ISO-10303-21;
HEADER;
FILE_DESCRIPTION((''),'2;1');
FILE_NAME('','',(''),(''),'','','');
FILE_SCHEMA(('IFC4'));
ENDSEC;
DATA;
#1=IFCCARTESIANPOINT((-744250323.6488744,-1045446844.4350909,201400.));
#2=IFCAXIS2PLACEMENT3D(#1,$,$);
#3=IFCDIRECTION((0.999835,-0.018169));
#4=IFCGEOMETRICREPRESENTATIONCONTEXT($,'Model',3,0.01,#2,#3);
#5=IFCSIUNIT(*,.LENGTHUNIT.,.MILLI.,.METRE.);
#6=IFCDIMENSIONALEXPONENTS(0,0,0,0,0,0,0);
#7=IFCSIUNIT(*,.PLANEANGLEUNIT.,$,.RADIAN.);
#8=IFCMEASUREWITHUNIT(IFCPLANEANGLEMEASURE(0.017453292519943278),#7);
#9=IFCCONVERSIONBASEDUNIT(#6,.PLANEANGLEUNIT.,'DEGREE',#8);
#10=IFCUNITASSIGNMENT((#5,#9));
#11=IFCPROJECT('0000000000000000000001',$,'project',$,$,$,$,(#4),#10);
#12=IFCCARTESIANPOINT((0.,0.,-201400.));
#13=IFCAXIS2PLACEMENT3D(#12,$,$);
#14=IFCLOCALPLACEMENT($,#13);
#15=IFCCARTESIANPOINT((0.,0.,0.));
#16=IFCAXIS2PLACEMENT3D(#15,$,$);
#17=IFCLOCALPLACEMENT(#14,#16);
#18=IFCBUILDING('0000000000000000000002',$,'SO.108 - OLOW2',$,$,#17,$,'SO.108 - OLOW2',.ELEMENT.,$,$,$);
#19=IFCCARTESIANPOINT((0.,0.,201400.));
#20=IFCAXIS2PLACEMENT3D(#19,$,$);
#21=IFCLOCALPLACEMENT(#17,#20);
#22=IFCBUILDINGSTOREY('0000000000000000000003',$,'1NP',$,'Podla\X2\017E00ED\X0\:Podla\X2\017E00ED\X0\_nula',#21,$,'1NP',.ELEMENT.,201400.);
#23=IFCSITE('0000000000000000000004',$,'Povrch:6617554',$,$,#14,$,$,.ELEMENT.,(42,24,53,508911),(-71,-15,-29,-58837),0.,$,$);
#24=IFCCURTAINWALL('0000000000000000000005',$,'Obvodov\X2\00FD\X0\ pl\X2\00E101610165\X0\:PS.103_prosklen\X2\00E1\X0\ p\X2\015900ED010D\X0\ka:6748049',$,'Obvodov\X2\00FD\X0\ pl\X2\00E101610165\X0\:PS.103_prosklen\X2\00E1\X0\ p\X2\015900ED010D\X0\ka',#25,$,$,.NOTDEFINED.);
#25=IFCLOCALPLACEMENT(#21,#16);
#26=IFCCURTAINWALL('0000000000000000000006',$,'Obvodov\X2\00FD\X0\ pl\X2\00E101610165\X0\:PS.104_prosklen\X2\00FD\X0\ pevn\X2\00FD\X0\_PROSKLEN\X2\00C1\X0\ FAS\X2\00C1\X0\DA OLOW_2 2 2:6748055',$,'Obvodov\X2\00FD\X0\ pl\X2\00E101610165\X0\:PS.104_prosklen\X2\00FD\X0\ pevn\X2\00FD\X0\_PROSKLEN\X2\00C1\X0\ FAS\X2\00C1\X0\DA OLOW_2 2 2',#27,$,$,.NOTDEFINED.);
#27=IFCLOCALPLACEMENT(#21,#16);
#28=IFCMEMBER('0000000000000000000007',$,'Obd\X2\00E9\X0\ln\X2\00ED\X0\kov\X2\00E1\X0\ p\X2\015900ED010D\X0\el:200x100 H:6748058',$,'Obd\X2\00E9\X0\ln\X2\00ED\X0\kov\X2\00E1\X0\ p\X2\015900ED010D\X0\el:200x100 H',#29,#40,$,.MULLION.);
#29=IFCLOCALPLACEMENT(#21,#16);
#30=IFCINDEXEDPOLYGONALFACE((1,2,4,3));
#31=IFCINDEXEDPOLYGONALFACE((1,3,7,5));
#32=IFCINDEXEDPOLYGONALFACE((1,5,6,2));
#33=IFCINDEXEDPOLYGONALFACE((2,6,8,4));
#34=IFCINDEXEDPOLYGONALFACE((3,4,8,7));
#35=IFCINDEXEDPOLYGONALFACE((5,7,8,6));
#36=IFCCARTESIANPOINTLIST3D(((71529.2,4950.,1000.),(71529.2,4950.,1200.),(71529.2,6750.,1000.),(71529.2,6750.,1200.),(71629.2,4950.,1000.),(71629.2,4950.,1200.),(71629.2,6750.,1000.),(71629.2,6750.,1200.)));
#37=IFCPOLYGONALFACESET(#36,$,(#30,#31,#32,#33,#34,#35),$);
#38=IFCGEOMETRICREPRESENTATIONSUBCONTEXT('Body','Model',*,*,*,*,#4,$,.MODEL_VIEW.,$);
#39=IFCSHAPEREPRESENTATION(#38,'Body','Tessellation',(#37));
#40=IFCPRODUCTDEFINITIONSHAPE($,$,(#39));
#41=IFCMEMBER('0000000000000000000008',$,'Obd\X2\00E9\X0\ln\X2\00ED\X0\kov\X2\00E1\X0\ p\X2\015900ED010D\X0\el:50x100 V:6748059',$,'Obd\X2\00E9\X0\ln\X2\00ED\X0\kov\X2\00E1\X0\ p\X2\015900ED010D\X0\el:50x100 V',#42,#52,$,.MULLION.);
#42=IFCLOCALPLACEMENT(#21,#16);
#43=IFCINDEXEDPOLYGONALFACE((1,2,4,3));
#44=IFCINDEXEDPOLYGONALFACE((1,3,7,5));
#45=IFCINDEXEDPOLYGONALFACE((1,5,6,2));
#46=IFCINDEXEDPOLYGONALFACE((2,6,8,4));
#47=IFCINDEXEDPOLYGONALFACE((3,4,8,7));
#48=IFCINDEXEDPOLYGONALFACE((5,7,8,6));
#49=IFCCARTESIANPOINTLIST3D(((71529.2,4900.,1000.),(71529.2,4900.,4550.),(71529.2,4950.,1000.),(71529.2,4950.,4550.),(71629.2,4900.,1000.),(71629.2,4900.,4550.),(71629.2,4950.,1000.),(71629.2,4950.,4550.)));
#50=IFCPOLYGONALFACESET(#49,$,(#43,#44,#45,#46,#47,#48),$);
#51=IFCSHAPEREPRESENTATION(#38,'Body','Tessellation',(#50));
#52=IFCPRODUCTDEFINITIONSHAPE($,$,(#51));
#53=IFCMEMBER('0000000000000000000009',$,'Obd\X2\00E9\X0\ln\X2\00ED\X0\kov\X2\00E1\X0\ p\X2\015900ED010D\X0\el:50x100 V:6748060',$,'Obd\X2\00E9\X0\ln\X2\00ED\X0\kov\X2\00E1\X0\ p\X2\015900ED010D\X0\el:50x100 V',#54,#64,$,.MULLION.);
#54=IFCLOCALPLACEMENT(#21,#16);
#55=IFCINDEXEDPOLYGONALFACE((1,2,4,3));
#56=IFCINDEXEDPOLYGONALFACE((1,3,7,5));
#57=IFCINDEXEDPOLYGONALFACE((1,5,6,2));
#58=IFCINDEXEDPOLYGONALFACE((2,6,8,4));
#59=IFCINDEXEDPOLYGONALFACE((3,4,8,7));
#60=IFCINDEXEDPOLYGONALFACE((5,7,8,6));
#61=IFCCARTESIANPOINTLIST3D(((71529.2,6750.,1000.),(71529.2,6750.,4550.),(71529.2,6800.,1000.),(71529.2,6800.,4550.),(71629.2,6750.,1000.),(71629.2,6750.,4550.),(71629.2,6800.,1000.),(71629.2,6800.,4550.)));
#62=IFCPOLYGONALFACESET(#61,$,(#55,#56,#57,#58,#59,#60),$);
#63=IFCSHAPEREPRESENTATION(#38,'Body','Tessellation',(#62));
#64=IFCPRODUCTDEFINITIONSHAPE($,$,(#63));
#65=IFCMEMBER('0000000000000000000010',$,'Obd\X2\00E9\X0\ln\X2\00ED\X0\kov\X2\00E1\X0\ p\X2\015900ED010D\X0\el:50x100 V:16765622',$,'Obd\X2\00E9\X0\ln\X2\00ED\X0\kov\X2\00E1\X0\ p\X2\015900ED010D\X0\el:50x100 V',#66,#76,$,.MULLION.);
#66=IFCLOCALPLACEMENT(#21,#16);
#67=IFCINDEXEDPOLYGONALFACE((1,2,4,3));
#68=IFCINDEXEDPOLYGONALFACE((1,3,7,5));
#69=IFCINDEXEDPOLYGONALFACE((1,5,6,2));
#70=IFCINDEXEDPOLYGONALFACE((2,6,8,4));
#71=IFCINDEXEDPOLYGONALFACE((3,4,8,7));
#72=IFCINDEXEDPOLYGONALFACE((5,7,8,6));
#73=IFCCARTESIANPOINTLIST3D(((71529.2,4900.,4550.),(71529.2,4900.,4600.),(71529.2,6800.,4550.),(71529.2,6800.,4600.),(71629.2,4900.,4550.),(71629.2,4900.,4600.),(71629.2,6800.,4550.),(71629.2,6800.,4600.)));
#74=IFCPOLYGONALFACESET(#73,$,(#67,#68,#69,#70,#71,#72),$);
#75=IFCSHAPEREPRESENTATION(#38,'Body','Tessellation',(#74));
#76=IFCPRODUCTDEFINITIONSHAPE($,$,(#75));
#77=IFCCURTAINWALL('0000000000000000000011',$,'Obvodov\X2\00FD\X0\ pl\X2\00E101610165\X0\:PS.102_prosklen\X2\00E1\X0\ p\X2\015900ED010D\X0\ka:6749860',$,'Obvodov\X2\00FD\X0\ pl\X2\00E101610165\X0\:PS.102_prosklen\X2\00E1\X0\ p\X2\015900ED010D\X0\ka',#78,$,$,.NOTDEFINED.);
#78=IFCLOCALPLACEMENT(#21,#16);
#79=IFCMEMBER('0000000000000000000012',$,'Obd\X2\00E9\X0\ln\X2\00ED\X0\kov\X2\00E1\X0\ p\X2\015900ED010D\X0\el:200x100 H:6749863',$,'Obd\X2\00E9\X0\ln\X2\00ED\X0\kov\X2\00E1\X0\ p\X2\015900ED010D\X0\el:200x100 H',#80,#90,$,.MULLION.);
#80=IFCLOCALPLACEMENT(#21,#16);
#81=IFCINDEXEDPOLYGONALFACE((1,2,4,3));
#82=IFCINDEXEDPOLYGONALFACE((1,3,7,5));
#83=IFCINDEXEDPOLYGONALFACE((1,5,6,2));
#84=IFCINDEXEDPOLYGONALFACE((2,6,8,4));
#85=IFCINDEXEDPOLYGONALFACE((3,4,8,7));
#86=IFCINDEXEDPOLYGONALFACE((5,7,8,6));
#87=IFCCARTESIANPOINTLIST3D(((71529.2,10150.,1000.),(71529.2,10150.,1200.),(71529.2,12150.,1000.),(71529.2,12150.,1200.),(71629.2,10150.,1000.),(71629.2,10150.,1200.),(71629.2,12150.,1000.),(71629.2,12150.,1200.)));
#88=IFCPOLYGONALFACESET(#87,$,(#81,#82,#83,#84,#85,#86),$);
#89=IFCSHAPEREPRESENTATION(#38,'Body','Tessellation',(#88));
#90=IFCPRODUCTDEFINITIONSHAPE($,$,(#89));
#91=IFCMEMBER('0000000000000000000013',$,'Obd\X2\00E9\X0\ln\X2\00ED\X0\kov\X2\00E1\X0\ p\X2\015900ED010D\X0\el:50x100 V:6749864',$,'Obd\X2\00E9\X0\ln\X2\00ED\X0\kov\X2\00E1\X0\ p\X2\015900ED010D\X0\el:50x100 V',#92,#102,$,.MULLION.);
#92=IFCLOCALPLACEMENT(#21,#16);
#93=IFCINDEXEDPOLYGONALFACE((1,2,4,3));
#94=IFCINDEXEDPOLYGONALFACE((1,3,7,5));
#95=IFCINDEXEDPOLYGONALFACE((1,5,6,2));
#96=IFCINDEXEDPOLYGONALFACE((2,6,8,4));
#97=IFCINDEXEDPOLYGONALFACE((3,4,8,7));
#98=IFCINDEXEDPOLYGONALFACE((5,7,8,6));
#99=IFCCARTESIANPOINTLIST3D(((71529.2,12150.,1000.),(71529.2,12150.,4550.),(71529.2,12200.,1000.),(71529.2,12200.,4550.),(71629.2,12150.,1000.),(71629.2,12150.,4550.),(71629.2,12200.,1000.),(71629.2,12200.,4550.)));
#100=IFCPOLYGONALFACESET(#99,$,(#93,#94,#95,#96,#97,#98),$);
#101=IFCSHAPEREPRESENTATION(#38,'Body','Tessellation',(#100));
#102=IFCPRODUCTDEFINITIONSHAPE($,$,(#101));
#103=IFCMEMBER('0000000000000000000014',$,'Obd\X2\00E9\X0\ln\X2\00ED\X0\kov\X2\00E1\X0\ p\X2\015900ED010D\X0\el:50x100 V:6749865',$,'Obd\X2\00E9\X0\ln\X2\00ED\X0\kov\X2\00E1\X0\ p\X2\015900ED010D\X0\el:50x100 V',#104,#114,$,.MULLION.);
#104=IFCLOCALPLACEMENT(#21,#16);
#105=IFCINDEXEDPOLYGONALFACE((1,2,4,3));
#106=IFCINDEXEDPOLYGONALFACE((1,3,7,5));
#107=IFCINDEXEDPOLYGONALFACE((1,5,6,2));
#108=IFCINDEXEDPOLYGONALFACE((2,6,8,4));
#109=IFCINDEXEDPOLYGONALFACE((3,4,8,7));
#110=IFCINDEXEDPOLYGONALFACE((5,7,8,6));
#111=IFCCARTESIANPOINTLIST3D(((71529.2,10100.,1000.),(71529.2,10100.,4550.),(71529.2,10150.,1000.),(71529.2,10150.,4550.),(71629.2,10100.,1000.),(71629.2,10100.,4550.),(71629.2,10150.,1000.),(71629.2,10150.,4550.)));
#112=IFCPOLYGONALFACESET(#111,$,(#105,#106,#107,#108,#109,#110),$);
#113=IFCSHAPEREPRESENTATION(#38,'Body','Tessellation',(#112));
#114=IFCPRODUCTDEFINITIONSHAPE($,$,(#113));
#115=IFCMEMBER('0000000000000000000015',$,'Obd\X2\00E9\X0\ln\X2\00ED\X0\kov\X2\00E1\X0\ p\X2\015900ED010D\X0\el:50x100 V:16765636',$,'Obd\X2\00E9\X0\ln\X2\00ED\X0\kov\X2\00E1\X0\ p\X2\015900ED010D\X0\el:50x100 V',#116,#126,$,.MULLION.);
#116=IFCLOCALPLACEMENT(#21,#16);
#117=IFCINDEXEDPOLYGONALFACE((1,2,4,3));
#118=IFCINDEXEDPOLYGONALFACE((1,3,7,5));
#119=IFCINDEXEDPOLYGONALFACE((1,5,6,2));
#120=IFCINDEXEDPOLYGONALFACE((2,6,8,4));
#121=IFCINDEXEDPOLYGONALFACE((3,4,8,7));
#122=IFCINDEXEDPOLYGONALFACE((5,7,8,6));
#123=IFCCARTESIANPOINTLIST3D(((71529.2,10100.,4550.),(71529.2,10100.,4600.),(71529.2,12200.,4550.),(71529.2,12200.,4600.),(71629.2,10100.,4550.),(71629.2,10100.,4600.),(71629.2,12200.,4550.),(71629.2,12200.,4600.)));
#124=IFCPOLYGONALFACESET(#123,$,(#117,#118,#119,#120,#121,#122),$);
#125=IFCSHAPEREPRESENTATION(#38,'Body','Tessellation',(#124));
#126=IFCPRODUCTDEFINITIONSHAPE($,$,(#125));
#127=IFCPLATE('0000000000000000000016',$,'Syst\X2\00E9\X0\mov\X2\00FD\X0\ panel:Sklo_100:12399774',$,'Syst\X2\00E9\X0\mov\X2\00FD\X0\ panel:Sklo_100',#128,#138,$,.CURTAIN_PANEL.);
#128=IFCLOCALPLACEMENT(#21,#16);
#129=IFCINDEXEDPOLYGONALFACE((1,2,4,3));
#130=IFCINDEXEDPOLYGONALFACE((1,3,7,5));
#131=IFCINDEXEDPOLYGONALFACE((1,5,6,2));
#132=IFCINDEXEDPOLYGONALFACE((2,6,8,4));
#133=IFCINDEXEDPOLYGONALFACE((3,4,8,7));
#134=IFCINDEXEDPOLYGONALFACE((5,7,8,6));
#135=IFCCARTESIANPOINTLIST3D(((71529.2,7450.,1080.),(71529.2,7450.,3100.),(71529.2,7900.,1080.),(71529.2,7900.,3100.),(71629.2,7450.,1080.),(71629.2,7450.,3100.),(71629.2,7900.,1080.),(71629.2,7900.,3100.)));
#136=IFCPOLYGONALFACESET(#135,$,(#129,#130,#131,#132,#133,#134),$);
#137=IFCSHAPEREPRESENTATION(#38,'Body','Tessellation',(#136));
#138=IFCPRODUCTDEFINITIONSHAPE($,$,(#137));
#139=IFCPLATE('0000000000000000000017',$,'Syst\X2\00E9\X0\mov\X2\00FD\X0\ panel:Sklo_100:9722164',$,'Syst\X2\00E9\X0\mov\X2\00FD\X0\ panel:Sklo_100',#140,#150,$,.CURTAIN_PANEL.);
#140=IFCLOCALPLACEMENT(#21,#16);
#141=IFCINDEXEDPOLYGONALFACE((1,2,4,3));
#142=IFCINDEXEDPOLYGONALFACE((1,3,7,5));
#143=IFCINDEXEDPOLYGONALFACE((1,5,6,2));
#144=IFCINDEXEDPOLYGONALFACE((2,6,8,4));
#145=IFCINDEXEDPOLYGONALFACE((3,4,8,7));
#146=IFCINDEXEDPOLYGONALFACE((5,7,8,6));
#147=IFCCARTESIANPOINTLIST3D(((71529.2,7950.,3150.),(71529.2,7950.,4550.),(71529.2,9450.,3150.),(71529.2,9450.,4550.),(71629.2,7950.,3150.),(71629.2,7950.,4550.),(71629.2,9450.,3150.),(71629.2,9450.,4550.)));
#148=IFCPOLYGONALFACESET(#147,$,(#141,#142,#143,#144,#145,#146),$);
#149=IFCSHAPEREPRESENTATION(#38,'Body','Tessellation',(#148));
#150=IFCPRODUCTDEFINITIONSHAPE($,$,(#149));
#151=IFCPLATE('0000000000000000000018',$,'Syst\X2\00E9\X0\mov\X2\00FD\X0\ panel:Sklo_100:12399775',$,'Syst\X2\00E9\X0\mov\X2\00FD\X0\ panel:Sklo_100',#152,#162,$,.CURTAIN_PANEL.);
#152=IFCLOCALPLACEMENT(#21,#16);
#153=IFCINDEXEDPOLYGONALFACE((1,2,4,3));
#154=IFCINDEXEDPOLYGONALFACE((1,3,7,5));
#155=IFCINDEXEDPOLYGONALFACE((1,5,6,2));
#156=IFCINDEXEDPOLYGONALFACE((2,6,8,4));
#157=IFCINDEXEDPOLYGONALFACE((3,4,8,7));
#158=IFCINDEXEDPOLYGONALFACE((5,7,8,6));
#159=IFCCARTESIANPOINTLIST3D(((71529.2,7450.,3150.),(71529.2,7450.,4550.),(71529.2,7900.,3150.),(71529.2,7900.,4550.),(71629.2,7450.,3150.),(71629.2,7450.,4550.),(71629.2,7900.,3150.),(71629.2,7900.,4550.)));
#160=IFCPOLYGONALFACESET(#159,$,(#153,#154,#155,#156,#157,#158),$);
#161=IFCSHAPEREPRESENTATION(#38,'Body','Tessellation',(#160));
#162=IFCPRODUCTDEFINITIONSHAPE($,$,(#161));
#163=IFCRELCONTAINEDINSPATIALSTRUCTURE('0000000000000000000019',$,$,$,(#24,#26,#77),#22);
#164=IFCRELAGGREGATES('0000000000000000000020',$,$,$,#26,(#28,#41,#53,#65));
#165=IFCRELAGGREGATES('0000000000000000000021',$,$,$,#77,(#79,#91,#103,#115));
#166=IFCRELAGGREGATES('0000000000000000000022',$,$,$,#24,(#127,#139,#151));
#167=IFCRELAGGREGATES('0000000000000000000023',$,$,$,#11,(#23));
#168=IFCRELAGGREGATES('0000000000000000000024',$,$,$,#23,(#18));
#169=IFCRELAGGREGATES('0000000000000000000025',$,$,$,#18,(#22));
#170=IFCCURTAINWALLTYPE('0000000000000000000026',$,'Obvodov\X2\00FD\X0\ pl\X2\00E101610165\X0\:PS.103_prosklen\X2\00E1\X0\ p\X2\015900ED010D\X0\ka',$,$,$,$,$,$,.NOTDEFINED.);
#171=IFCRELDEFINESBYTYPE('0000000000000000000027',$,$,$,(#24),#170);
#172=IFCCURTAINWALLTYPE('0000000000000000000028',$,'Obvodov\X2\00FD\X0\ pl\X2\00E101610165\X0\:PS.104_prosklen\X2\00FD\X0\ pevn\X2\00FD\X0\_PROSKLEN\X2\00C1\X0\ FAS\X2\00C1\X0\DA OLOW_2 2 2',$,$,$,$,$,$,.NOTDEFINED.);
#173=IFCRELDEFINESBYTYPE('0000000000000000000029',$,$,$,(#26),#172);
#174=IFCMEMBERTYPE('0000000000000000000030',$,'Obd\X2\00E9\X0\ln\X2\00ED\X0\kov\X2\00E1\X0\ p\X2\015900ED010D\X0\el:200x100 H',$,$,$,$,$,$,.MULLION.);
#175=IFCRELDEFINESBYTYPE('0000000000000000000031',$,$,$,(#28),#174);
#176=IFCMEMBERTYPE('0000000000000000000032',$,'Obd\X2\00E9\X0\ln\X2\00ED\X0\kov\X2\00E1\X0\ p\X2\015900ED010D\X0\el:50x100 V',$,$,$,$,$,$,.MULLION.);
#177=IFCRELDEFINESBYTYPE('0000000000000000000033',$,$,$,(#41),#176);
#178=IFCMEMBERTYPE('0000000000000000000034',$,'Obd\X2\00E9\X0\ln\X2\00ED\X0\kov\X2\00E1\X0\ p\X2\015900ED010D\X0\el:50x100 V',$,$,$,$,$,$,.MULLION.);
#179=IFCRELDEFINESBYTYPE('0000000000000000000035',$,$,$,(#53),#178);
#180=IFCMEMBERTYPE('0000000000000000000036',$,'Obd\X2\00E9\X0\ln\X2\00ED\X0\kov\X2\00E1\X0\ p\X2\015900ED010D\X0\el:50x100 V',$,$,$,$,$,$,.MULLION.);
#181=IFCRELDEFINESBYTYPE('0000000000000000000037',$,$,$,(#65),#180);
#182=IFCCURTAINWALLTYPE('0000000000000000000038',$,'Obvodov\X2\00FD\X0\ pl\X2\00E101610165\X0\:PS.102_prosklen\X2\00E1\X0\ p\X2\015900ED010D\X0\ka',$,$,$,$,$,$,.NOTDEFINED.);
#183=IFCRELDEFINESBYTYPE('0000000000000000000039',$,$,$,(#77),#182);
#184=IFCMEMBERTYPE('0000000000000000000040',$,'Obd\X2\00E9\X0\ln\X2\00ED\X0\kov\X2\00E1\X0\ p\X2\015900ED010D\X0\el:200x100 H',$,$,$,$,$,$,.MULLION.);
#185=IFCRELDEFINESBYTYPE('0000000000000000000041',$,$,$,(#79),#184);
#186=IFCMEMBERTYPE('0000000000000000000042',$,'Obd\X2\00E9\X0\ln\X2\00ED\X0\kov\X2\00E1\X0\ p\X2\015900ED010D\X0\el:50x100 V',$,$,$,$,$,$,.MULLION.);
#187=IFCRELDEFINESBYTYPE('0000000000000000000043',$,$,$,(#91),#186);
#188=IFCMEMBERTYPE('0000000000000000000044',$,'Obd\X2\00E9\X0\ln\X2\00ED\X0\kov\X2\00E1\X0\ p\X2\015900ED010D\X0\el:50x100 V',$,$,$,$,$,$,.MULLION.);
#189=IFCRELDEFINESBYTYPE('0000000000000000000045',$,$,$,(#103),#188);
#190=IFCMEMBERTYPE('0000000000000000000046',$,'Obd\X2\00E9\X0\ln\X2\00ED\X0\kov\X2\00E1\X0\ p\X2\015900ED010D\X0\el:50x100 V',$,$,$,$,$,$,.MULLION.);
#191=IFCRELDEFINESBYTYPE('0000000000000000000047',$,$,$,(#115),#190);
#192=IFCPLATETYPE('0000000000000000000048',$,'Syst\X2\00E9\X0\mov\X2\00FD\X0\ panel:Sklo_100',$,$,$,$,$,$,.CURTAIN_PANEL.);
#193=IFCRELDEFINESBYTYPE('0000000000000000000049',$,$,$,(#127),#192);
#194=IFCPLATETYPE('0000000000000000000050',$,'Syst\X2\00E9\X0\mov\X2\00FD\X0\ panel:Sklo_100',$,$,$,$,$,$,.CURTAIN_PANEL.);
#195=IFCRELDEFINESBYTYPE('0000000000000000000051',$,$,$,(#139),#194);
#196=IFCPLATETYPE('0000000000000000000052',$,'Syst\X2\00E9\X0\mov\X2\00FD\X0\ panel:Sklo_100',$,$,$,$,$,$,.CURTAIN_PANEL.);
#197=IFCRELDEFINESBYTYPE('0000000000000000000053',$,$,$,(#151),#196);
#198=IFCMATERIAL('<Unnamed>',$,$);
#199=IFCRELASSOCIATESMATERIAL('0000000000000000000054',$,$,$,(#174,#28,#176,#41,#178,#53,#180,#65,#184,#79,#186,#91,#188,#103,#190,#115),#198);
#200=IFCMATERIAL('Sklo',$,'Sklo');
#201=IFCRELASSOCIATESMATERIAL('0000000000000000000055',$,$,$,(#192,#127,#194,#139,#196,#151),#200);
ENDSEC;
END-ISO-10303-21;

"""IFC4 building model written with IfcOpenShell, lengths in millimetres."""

from ifc_helpers import new_model, entity, si_unit, converted_unit, direction, frame, origin, place, context, subcontext, project, spatial, indexed_curve, outline, extrude, source, transform, mapped, material, type_object, type_shapes, element, aggregate, save


model = new_model("IFC4")

# Units and contexts
model_context = context("Model", 3, precision=0.01, world=frame((-744250323.6488744, -1045446844.4350909, 201400.0)), true_north=direction((0.999835, -0.018169)))
body_context = subcontext(model_context, "Body", "Model", "MODEL_VIEW")
ifc_project = project(units=[si_unit("LENGTHUNIT", "METRE", prefix="MILLI"), converted_unit("PLANEANGLEUNIT", "DEGREE", entity("IfcPlaneAngleMeasure", 0.017453292519943278), si_unit("PLANEANGLEUNIT", "RADIAN"), dimensions=[0, 0, 0, 0, 0, 0, 0])], contexts=[model_context])

# Site, building, storey
site_placement = place(None, frame((0.0, 0.0, -201400.0)))
site = spatial("IfcSite", under=ifc_project, at=site_placement, Name="Povrch:6617554", CompositionType="ELEMENT", RefLatitude=(42, 24, 53, 508911), RefLongitude=(-71, -15, -29, -58837), RefElevation=0.0)
building_placement = place(site_placement, origin())
building = spatial("IfcBuilding", under=site, at=building_placement, Name="SO.108 - OLOW2", LongName="SO.108 - OLOW2", CompositionType="ELEMENT")
storey_placement = place(building_placement, frame((0.0, 0.0, 201400.0)))
storey = spatial("IfcBuildingStorey", under=building, at=storey_placement, Name="1NP", ObjectType="Podlaží:Podlaží_nula", LongName="1NP", CompositionType="ELEMENT", Elevation=201400.0)

# Curtain walls, members
curtain_wall_type_1 = type_object("IfcCurtainWallType", Name="Obvodový plášť:PS.103_prosklená příčka", PredefinedType="NOTDEFINED")
curtain_wall_1_placement = place(storey_placement, frame((0.0, 0.0, -201400.0)))
curtain_wall_1 = element("IfcCurtainWall", 1, at=curtain_wall_1_placement, inside=storey, type_object=curtain_wall_type_1, Name="Obvodový plášť:PS.103_prosklená příčka:6748049", ObjectType="Obvodový plášť:PS.103_prosklená příčka", PredefinedType="NOTDEFINED")
ifc_material_1 = material(Name="<Unnamed>")
curtain_wall_type_2 = type_object("IfcCurtainWallType", Name="Obvodový plášť:PS.104_prosklený pevný_PROSKLENÁ FASÁDA OLOW_2 2 2", PredefinedType="NOTDEFINED")
curtain_wall_2_placement = place(storey_placement, frame((0.0, 0.0, -201400.0)))
curtain_wall_2 = element("IfcCurtainWall", 2, at=curtain_wall_2_placement, inside=storey, type_object=curtain_wall_type_2, Name="Obvodový plášť:PS.104_prosklený pevný_PROSKLENÁ FASÁDA OLOW_2 2 2:6748055", ObjectType="Obvodový plášť:PS.104_prosklený pevný_PROSKLENÁ FASÁDA OLOW_2 2 2", PredefinedType="NOTDEFINED")
member_type_1 = type_object("IfcMemberType", Name="Obdélníková příčel:200x100 H", PredefinedType="MULLION", material=ifc_material_1)
shared_shape_1 = source(origin(), body_context, "Body", "SweptSolid", [
    extrude(outline(indexed_curve([(-100.0, -50.0), (100.0, -50.0), (100.0, 50.0), (-100.0, 50.0), (-100.0, -50.0)], self_intersect=False)), frame((-100.0, -50.0, -1800.0), z_axis=(0.0, 0.0, 1.0), x_axis=(-1.0, 0.0, 0.0)), (0.0, 0.0, 1.0), 1800.0),
])
type_shapes(member_type_1, [shared_shape_1])
member_1_placement = place(curtain_wall_2_placement, frame((71529.2, 6750.0, 202400.0), z_axis=(0.0, 1.0, 0.0), x_axis=(0.0, 0.0, -1.0)))
member_1 = element("IfcMember", 3, at=member_1_placement, type_object=member_type_1, material=ifc_material_1, Name="Obdélníková příčel:200x100 H:6748058", ObjectType="Obdélníková příčel:200x100 H", PredefinedType="MULLION", context=body_context, shape_type="MappedRepresentation", body=[
    mapped(shared_shape_1, transform((0.0, 0.0, 0.0), scale=1.0)),
])
member_type_2 = type_object("IfcMemberType", Name="Obdélníková příčel:50x100 V", PredefinedType="MULLION", material=ifc_material_1)
shared_shape_2 = source(origin(), body_context, "Body", "SweptSolid", [
    extrude(outline(indexed_curve([(-25.0, -50.0), (25.0, -50.0), (25.0, 50.0), (-25.0, 50.0), (-25.0, -50.0)], self_intersect=False)), frame((-25.0, -50.0, -3550.0), z_axis=(0.0, 0.0, 1.0), x_axis=(-1.0, 0.0, 0.0)), (0.0, 0.0, 1.0), 3550.0),
])
type_shapes(member_type_2, [shared_shape_2])
member_2_placement = place(curtain_wall_2_placement, frame((71529.2, 4900.0, 202400.0), z_axis=(0.0, 0.0, -1.0), x_axis=(0.0, -1.0, 0.0)))
member_2 = element("IfcMember", 4, at=member_2_placement, type_object=member_type_2, material=ifc_material_1, Name="Obdélníková příčel:50x100 V:6748059", ObjectType="Obdélníková příčel:50x100 V", PredefinedType="MULLION", context=body_context, shape_type="MappedRepresentation", body=[
    mapped(shared_shape_2, transform((0.0, 0.0, 0.0), scale=1.0)),
])
member_type_3 = type_object("IfcMemberType", Name="Obdélníková příčel:50x100 V", PredefinedType="MULLION", material=ifc_material_1)
shared_shape_3 = source(origin(), body_context, "Body", "SweptSolid", [
    extrude(outline(indexed_curve([(-25.0, -50.0), (25.0, -50.0), (25.0, 50.0), (-25.0, 50.0), (-25.0, -50.0)], self_intersect=False)), frame((-25.0, -50.0, -3550.0), z_axis=(0.0, 0.0, 1.0), x_axis=(-1.0, 0.0, 0.0)), (0.0, 0.0, 1.0), 3550.0),
])
type_shapes(member_type_3, [shared_shape_3])
member_3_placement = place(curtain_wall_2_placement, frame((71529.2, 6800.0, 205950.0), z_axis=(0.0, 0.0, 1.0), x_axis=(0.0, 1.0, 0.0)))
member_3 = element("IfcMember", 5, at=member_3_placement, type_object=member_type_3, material=ifc_material_1, Name="Obdélníková příčel:50x100 V:6748060", ObjectType="Obdélníková příčel:50x100 V", PredefinedType="MULLION", context=body_context, shape_type="MappedRepresentation", body=[
    mapped(shared_shape_3, transform((0.0, 0.0, 0.0), scale=1.0)),
])
member_type_4 = type_object("IfcMemberType", Name="Obdélníková příčel:50x100 V", PredefinedType="MULLION", material=ifc_material_1)
shared_shape_4 = source(origin(), body_context, "Body", "SweptSolid", [
    extrude(outline(indexed_curve([(-25.0, -50.0), (25.0, -50.0), (25.0, 50.0), (-25.0, 50.0), (-25.0, -50.0)], self_intersect=False)), frame((-25.0, -50.0, -1900.0), z_axis=(0.0, 0.0, 1.0), x_axis=(-1.0, 0.0, 0.0)), (0.0, 0.0, 1.0), 1900.0),
])
type_shapes(member_type_4, [shared_shape_4])
member_4_placement = place(curtain_wall_2_placement, frame((71529.2, 4900.0, 206000.0), z_axis=(0.0, -1.0, 0.0), x_axis=(0.0, 0.0, 1.0)))
member_4 = element("IfcMember", 6, at=member_4_placement, type_object=member_type_4, material=ifc_material_1, Name="Obdélníková příčel:50x100 V:16765622", ObjectType="Obdélníková příčel:50x100 V", PredefinedType="MULLION", context=body_context, shape_type="MappedRepresentation", body=[
    mapped(shared_shape_4, transform((0.0, 0.0, 0.0), scale=1.0)),
])
curtain_wall_type_3 = type_object("IfcCurtainWallType", Name="Obvodový plášť:PS.102_prosklená příčka", PredefinedType="NOTDEFINED")
curtain_wall_3_placement = place(storey_placement, frame((0.0, 0.0, -201400.0)))
curtain_wall_3 = element("IfcCurtainWall", 7, at=curtain_wall_3_placement, inside=storey, type_object=curtain_wall_type_3, Name="Obvodový plášť:PS.102_prosklená příčka:6749860", ObjectType="Obvodový plášť:PS.102_prosklená příčka", PredefinedType="NOTDEFINED")
member_type_5 = type_object("IfcMemberType", Name="Obdélníková příčel:200x100 H", PredefinedType="MULLION", material=ifc_material_1)
shared_shape_5 = source(origin(), body_context, "Body", "SweptSolid", [
    extrude(outline(indexed_curve([(-100.0, -50.0), (100.0, -50.0), (100.0, 50.0), (-100.0, 50.0), (-100.0, -50.0)], self_intersect=False)), frame((-100.0, 50.0, -2000.0), z_axis=(0.0, 0.0, 1.0), x_axis=(-1.0, 0.0, 0.0)), (0.0, 0.0, 1.0), 2000.0),
])
type_shapes(member_type_5, [shared_shape_5])
member_5_placement = place(curtain_wall_3_placement, frame((71529.2, 10150.0, 202400.0), z_axis=(0.0, -1.0, 0.0), x_axis=(0.0, 0.0, -1.0)))
member_5 = element("IfcMember", 8, at=member_5_placement, type_object=member_type_5, material=ifc_material_1, Name="Obdélníková příčel:200x100 H:6749863", ObjectType="Obdélníková příčel:200x100 H", PredefinedType="MULLION", context=body_context, shape_type="MappedRepresentation", body=[
    mapped(shared_shape_5, transform((0.0, 0.0, 0.0), scale=1.0)),
])
member_type_6 = type_object("IfcMemberType", Name="Obdélníková příčel:50x100 V", PredefinedType="MULLION", material=ifc_material_1)
shared_shape_6 = source(origin(), body_context, "Body", "SweptSolid", [
    extrude(outline(indexed_curve([(-25.0, -50.0), (25.0, -50.0), (25.0, 50.0), (-25.0, 50.0), (-25.0, -50.0)], self_intersect=False)), frame((-25.0, 50.0, -3550.0), z_axis=(0.0, 0.0, 1.0), x_axis=(-1.0, 0.0, 0.0)), (0.0, 0.0, 1.0), 3550.0),
])
type_shapes(member_type_6, [shared_shape_6])
member_6_placement = place(curtain_wall_3_placement, frame((71529.2, 12200.0, 202400.0), z_axis=(0.0, 0.0, -1.0), x_axis=(0.0, 1.0, 0.0)))
member_6 = element("IfcMember", 9, at=member_6_placement, type_object=member_type_6, material=ifc_material_1, Name="Obdélníková příčel:50x100 V:6749864", ObjectType="Obdélníková příčel:50x100 V", PredefinedType="MULLION", context=body_context, shape_type="MappedRepresentation", body=[
    mapped(shared_shape_6, transform((0.0, 0.0, 0.0), scale=1.0)),
])
member_type_7 = type_object("IfcMemberType", Name="Obdélníková příčel:50x100 V", PredefinedType="MULLION", material=ifc_material_1)
shared_shape_7 = source(origin(), body_context, "Body", "SweptSolid", [
    extrude(outline(indexed_curve([(-25.0, -50.0), (25.0, -50.0), (25.0, 50.0), (-25.0, 50.0), (-25.0, -50.0)], self_intersect=False)), frame((-25.0, 50.0, -3550.0), z_axis=(0.0, 0.0, 1.0), x_axis=(-1.0, 0.0, 0.0)), (0.0, 0.0, 1.0), 3550.0),
])
type_shapes(member_type_7, [shared_shape_7])
member_7_placement = place(curtain_wall_3_placement, frame((71529.2, 10100.0, 205950.0), z_axis=(0.0, 0.0, 1.0), x_axis=(0.0, -1.0, 0.0)))
member_7 = element("IfcMember", 10, at=member_7_placement, type_object=member_type_7, material=ifc_material_1, Name="Obdélníková příčel:50x100 V:6749865", ObjectType="Obdélníková příčel:50x100 V", PredefinedType="MULLION", context=body_context, shape_type="MappedRepresentation", body=[
    mapped(shared_shape_7, transform((0.0, 0.0, 0.0), scale=1.0)),
])
member_type_8 = type_object("IfcMemberType", Name="Obdélníková příčel:50x100 V", PredefinedType="MULLION", material=ifc_material_1)
shared_shape_8 = source(origin(), body_context, "Body", "SweptSolid", [
    extrude(outline(indexed_curve([(-25.0, -50.0), (25.0, -50.0), (25.0, 50.0), (-25.0, 50.0), (-25.0, -50.0)], self_intersect=False)), frame((-25.0, 50.0, -2100.0), z_axis=(0.0, 0.0, 1.0), x_axis=(-1.0, 0.0, 0.0)), (0.0, 0.0, 1.0), 2100.0),
])
type_shapes(member_type_8, [shared_shape_8])
member_8_placement = place(curtain_wall_3_placement, frame((71529.2, 12200.0, 206000.0), z_axis=(0.0, 1.0, 0.0), x_axis=(0.0, 0.0, 1.0)))
member_8 = element("IfcMember", 11, at=member_8_placement, type_object=member_type_8, material=ifc_material_1, Name="Obdélníková příčel:50x100 V:16765636", ObjectType="Obdélníková příčel:50x100 V", PredefinedType="MULLION", context=body_context, shape_type="MappedRepresentation", body=[
    mapped(shared_shape_8, transform((0.0, 0.0, 0.0), scale=1.0)),
])

# Plates
ifc_material_2 = material(Name="Sklo", Category="Sklo")
plate_type_1 = type_object("IfcPlateType", Name="Systémový panel:Sklo_100", PredefinedType="CURTAIN_PANEL", material=ifc_material_2)
shared_shape_9 = source(origin(), body_context, "Body", "SweptSolid", [
    extrude(outline(indexed_curve([(-50.0, -225.0), (50.0, -225.0), (50.0, 225.0), (-50.0, 225.0), (-50.0, -225.0)], self_intersect=False)), frame((0.0, 50.0, 0.0), z_axis=(0.0, 0.0, 1.0), x_axis=(0.0, 1.0, 0.0)), (0.0, 0.0, 1.0), 2020.0),
])
type_shapes(plate_type_1, [shared_shape_9])
plate_1_placement = place(curtain_wall_1_placement, frame((71529.2, 7675.0, 202480.0), z_axis=(0.0, 0.0, 1.0), x_axis=(0.0, -1.0, 0.0)))
plate_1 = element("IfcPlate", 12, at=plate_1_placement, type_object=plate_type_1, material=ifc_material_2, Name="Systémový panel:Sklo_100:12399774", ObjectType="Systémový panel:Sklo_100", PredefinedType="CURTAIN_PANEL", context=body_context, shape_type="MappedRepresentation", body=[
    mapped(shared_shape_9, transform((0.0, 0.0, 0.0), scale=1.0)),
])
plate_type_2 = type_object("IfcPlateType", Name="Systémový panel:Sklo_100", PredefinedType="CURTAIN_PANEL", material=ifc_material_2)
shared_shape_10 = source(origin(), body_context, "Body", "SweptSolid", [
    extrude(outline(indexed_curve([(-50.0, -750.0), (50.0, -750.0), (50.0, 750.0), (-50.0, 750.0), (-50.0, -750.0)], self_intersect=False)), frame((0.0, 50.0, 0.0), z_axis=(0.0, 0.0, 1.0), x_axis=(0.0, 1.0, 0.0)), (0.0, 0.0, 1.0), 1400.0),
])
type_shapes(plate_type_2, [shared_shape_10])
plate_2_placement = place(curtain_wall_1_placement, frame((71529.2, 8700.0, 204550.0), z_axis=(0.0, 0.0, 1.0), x_axis=(0.0, -1.0, 0.0)))
plate_2 = element("IfcPlate", 13, at=plate_2_placement, type_object=plate_type_2, material=ifc_material_2, Name="Systémový panel:Sklo_100:9722164", ObjectType="Systémový panel:Sklo_100", PredefinedType="CURTAIN_PANEL", context=body_context, shape_type="MappedRepresentation", body=[
    mapped(shared_shape_10, transform((0.0, 0.0, 0.0), scale=1.0)),
])
plate_type_3 = type_object("IfcPlateType", Name="Systémový panel:Sklo_100", PredefinedType="CURTAIN_PANEL", material=ifc_material_2)
shared_shape_11 = source(origin(), body_context, "Body", "SweptSolid", [
    extrude(outline(indexed_curve([(-50.0, -225.0), (50.0, -225.0), (50.0, 225.0), (-50.0, 225.0), (-50.0, -225.0)], self_intersect=False)), frame((0.0, 50.0, 0.0), z_axis=(0.0, 0.0, 1.0), x_axis=(0.0, 1.0, 0.0)), (0.0, 0.0, 1.0), 1400.0),
])
type_shapes(plate_type_3, [shared_shape_11])
plate_3_placement = place(curtain_wall_1_placement, frame((71529.2, 7675.0, 204550.0), z_axis=(0.0, 0.0, 1.0), x_axis=(0.0, -1.0, 0.0)))
plate_3 = element("IfcPlate", 14, at=plate_3_placement, type_object=plate_type_3, material=ifc_material_2, Name="Systémový panel:Sklo_100:12399775", ObjectType="Systémový panel:Sklo_100", PredefinedType="CURTAIN_PANEL", context=body_context, shape_type="MappedRepresentation", body=[
    mapped(shared_shape_11, transform((0.0, 0.0, 0.0), scale=1.0)),
])
aggregate(curtain_wall_2, [member_1, member_2, member_3, member_4])
aggregate(curtain_wall_3, [member_5, member_6, member_7, member_8])

aggregate(curtain_wall_1, [plate_1, plate_2, plate_3])

save(model, "model.ifc")
